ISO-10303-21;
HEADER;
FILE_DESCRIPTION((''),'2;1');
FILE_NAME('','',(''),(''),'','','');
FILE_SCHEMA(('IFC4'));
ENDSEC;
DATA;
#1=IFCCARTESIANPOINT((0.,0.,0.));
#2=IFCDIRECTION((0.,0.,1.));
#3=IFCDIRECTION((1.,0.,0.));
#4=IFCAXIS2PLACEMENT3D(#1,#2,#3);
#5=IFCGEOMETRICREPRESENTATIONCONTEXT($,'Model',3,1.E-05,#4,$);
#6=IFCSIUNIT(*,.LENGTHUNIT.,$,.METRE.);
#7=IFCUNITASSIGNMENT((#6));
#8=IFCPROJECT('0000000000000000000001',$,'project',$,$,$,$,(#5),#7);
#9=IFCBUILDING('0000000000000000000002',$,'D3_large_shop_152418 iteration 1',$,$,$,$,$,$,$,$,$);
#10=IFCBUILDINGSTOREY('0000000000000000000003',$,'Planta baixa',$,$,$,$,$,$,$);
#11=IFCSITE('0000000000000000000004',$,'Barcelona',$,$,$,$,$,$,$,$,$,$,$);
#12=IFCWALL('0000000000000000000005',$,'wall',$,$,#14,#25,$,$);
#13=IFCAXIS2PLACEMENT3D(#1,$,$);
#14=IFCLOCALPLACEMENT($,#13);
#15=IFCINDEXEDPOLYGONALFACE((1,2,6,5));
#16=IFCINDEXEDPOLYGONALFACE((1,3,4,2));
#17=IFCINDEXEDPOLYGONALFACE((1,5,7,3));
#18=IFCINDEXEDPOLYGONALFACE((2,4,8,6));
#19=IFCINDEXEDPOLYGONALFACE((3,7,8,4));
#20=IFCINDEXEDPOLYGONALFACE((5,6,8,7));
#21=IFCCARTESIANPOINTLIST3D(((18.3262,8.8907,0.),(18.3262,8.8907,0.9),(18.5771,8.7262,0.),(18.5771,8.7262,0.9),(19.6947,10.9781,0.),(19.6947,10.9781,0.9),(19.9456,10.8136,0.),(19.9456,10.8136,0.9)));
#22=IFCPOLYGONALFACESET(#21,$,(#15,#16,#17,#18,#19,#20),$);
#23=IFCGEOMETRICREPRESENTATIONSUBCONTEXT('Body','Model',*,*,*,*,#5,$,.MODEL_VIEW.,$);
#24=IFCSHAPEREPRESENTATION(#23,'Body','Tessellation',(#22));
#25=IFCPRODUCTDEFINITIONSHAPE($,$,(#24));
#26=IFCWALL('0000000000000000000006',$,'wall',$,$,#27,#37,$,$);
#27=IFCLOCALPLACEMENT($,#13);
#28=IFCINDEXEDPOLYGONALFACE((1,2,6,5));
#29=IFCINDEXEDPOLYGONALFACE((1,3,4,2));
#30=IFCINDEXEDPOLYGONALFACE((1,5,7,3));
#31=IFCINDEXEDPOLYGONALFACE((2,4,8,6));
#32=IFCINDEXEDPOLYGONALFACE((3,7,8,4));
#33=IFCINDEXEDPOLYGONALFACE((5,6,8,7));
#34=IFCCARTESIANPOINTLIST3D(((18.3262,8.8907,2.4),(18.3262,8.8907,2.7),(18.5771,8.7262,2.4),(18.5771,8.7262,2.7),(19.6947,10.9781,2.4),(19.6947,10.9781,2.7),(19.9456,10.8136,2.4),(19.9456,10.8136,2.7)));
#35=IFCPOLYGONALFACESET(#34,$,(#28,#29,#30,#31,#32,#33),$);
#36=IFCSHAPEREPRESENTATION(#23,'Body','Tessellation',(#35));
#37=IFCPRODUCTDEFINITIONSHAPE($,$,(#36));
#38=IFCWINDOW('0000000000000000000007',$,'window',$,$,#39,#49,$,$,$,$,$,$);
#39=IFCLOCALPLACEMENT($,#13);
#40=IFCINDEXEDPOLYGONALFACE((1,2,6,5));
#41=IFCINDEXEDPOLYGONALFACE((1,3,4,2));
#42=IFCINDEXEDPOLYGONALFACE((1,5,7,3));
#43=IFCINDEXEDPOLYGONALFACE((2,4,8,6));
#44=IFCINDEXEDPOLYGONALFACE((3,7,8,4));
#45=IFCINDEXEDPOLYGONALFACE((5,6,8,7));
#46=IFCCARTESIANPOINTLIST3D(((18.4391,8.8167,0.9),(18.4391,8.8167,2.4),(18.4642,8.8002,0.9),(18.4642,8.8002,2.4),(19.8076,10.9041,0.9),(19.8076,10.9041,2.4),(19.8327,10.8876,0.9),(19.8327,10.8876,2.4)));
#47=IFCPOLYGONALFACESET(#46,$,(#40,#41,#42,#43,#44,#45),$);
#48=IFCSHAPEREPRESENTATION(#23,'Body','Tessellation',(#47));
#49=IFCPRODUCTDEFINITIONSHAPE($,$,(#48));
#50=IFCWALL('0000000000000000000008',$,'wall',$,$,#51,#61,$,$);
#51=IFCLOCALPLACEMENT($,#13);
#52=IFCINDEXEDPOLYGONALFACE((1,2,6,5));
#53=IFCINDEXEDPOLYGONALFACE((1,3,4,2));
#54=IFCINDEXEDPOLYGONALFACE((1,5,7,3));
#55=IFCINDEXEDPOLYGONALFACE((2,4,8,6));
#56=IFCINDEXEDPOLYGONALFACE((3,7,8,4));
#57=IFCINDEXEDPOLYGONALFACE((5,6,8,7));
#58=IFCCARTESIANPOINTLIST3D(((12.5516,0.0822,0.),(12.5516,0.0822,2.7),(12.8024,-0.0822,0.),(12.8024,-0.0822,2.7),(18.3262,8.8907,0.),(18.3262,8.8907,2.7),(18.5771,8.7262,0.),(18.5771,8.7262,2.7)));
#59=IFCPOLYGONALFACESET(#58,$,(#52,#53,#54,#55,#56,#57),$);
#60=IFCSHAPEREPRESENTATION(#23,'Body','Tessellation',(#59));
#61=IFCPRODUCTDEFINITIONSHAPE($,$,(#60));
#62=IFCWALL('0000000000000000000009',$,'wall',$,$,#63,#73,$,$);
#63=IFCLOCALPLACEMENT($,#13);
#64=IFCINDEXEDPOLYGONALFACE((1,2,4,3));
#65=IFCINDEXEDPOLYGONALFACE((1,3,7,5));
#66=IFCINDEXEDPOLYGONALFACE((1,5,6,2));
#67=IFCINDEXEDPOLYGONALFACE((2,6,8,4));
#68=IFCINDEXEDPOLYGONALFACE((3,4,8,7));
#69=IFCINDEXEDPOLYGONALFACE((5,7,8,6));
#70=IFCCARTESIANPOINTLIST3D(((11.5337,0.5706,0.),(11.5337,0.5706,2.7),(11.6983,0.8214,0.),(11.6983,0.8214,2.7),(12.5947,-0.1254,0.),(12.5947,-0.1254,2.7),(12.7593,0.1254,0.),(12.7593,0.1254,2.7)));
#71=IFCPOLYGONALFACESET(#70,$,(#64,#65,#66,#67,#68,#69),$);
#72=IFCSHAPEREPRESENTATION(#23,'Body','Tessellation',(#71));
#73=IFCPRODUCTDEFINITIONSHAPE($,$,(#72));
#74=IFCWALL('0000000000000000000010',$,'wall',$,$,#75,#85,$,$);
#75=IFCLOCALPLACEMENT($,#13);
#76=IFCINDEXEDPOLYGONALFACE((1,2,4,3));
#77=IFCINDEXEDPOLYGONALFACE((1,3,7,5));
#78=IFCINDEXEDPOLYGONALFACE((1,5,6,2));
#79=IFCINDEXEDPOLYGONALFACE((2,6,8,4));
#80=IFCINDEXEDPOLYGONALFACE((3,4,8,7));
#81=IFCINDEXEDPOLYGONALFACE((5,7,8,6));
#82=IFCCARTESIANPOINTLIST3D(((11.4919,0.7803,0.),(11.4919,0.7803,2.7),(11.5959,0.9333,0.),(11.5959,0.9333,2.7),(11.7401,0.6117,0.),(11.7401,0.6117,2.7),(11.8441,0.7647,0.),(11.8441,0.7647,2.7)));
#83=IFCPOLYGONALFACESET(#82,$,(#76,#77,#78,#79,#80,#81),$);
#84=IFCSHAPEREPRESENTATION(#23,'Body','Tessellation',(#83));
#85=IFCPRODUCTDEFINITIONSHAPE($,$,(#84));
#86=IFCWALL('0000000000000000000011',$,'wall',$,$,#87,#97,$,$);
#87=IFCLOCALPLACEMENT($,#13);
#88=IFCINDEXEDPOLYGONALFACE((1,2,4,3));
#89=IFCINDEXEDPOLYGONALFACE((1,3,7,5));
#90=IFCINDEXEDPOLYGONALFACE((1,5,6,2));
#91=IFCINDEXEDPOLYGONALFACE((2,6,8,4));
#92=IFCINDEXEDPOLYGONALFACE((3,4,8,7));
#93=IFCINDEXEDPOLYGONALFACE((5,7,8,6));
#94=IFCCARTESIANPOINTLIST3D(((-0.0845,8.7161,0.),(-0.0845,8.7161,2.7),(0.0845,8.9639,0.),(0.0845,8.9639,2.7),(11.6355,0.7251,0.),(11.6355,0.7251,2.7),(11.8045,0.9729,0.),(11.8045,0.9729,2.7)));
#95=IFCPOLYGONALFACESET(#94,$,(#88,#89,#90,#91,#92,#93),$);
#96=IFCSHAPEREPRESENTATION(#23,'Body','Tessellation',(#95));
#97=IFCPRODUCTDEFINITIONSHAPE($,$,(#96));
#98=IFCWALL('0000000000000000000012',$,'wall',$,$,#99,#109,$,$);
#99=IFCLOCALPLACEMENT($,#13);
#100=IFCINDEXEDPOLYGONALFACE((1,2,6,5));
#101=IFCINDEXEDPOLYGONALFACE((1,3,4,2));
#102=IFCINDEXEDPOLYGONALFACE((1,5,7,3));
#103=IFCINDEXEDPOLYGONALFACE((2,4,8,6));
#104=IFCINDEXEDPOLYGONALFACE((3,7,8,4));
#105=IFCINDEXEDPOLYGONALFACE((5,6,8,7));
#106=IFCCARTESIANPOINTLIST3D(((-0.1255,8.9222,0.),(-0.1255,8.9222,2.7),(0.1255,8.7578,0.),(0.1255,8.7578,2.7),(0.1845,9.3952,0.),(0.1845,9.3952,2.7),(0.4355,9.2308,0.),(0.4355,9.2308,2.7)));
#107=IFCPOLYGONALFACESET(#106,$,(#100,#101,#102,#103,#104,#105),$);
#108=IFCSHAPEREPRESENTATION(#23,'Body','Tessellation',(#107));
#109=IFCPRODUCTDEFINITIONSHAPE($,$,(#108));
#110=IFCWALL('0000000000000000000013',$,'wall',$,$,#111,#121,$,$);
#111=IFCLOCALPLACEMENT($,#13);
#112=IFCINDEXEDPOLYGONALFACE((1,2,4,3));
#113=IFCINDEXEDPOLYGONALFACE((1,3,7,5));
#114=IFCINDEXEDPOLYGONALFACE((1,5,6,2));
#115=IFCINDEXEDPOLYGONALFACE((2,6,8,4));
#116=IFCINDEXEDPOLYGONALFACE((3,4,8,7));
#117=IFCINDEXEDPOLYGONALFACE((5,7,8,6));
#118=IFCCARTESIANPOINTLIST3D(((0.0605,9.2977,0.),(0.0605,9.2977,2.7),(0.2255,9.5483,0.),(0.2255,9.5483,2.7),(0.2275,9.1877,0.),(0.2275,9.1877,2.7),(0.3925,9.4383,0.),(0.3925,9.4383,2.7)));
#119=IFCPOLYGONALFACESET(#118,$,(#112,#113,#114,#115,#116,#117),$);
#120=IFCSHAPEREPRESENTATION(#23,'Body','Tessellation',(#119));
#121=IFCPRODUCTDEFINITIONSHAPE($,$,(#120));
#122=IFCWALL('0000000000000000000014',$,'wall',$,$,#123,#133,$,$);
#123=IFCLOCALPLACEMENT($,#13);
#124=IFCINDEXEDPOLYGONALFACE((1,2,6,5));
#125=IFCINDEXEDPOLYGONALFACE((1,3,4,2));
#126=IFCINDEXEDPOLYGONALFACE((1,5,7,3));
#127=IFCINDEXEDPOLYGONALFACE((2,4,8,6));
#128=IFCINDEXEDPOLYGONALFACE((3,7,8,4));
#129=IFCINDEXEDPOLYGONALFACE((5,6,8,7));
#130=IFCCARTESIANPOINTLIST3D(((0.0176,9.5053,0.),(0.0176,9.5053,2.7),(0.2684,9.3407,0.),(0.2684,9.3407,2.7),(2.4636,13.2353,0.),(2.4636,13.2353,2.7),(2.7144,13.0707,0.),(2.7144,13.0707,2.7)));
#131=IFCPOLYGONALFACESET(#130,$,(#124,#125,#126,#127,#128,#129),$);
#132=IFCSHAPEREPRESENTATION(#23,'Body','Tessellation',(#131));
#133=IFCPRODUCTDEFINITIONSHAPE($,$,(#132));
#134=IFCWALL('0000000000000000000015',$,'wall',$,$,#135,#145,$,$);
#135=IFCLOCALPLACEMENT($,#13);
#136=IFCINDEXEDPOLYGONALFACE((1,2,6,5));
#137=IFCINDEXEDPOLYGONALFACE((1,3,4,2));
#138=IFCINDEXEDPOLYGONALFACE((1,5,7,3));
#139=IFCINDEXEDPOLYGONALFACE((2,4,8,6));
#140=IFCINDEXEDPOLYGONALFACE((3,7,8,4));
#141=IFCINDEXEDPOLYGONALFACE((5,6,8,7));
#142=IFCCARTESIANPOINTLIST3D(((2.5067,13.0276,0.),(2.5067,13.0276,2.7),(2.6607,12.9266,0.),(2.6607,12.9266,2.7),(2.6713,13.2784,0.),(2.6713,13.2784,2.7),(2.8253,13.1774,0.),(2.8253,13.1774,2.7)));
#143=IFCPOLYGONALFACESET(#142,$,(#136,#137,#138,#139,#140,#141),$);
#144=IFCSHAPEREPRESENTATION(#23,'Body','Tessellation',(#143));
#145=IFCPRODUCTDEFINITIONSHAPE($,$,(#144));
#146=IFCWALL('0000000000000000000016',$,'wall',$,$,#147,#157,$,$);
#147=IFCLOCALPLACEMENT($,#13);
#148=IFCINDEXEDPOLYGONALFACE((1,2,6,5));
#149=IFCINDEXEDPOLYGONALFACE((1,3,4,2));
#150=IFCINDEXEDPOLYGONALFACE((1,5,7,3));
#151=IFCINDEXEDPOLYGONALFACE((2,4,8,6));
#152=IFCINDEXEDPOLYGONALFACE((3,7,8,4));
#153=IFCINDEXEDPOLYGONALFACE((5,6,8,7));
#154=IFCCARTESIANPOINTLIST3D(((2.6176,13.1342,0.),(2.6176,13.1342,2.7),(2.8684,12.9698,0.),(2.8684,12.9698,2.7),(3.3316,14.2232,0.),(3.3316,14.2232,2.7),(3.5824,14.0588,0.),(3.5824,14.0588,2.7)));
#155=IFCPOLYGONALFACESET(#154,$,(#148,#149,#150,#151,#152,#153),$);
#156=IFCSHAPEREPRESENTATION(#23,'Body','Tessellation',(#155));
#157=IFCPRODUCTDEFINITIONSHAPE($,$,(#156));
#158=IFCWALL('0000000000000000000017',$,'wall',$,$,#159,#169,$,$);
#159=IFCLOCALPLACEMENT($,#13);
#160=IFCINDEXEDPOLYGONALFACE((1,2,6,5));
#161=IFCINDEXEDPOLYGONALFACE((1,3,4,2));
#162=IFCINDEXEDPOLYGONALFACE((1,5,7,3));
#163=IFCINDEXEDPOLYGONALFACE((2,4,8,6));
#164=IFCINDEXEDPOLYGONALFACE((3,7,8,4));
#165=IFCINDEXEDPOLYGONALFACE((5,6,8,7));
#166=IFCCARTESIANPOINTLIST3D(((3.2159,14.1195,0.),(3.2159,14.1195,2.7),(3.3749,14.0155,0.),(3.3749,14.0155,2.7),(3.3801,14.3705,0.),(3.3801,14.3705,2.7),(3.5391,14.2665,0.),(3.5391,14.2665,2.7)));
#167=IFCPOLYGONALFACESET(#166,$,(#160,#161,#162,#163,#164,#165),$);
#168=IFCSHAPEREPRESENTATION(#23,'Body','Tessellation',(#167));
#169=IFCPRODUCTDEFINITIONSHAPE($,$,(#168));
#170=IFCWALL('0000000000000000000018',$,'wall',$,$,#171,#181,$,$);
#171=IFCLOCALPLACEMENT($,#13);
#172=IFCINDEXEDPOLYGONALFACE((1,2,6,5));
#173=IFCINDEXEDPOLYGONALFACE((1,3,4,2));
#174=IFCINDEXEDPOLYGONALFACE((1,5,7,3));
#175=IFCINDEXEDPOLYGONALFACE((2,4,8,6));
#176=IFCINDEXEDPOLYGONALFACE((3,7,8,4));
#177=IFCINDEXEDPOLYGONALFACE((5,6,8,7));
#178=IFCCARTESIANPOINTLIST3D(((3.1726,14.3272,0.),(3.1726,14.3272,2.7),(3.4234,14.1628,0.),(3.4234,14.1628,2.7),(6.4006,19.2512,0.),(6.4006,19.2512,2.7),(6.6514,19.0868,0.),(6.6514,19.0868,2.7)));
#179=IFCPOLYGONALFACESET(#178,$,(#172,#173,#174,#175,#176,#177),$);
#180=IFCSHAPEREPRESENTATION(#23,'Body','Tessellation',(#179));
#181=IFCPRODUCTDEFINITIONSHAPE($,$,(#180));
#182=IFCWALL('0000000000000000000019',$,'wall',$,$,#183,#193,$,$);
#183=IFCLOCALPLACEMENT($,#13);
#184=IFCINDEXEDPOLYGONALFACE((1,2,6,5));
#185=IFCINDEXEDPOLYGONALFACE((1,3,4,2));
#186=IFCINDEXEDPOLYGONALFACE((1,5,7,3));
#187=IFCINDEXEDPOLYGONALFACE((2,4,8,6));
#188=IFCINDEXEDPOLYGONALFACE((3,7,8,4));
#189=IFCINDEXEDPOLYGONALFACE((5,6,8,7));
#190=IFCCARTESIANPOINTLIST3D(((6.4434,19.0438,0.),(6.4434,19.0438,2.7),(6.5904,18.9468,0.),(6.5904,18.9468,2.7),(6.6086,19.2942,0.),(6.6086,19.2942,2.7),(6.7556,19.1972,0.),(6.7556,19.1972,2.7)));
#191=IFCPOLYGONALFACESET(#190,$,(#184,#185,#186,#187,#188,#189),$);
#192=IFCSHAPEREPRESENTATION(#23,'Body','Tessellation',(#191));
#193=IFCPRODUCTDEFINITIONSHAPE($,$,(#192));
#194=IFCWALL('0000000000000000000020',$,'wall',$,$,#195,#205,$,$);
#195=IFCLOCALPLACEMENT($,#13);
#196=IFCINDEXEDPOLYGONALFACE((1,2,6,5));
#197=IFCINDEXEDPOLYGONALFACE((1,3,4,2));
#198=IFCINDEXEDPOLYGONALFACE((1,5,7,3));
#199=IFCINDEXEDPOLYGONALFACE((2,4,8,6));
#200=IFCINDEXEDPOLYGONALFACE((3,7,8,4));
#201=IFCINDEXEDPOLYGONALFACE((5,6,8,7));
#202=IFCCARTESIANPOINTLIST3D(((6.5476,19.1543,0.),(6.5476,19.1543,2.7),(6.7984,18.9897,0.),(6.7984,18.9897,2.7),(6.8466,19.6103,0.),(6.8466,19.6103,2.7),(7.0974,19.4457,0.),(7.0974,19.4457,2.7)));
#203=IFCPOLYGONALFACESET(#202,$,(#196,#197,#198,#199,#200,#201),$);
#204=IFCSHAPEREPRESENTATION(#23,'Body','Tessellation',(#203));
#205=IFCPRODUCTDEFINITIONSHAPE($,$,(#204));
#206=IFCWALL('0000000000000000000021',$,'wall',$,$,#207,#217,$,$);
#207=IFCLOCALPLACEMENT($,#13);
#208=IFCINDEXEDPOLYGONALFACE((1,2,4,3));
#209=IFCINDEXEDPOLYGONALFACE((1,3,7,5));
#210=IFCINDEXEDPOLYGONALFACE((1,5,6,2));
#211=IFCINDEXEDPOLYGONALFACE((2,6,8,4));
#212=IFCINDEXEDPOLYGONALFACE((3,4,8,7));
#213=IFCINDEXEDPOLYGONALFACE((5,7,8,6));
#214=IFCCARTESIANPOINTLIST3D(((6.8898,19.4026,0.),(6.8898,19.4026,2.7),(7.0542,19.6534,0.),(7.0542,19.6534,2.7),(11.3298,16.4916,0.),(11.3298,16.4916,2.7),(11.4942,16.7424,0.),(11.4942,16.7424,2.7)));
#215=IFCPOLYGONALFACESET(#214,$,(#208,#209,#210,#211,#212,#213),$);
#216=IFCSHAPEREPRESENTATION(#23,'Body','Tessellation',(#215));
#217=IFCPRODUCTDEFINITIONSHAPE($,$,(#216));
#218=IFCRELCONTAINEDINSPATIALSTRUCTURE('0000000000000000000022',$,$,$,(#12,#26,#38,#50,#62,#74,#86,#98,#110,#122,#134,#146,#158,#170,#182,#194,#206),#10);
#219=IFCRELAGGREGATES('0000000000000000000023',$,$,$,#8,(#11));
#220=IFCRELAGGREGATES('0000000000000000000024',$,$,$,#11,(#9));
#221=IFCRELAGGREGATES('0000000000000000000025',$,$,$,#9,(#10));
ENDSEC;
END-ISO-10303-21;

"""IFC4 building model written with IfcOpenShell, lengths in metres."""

from ifc_helpers import new_model, si_unit, frame, origin, origin_with_axes, place, context, subcontext, project, spatial, polyline, outline, extrude, element, save


model = new_model("IFC4")

# Units and contexts
model_context = context("Model", 3, precision=1e-05, world=origin_with_axes())
body_context = subcontext(model_context, "Body", "Model", "MODEL_VIEW")
ifc_project = project(units=[si_unit("LENGTHUNIT", "METRE")], contexts=[model_context])

# Site, building, storey
site = spatial("IfcSite", under=ifc_project, Name="Barcelona")
building = spatial("IfcBuilding", under=site, Name="D3_large_shop_152418 iteration 1")
storey = spatial("IfcBuildingStorey", under=building, Name="Planta baixa")

# Walls
wall_1_placement = place(None, origin_with_axes())
element("IfcWall", 1, at=wall_1_placement, inside=storey, Name="wall", context=body_context, shape_type="SweptSolid", body=[
    extrude(outline(polyline([(19.9456, 10.8136), (18.5771, 8.7262), (18.3262, 8.8907), (19.6947, 10.9781), (19.9456, 10.8136)])), origin(), (0.0, 0.0, 1.0), 0.9),
])
wall_2_placement = place(None, origin_with_axes())
element("IfcWall", 2, at=wall_2_placement, inside=storey, Name="wall", context=body_context, shape_type="SweptSolid", body=[
    extrude(outline(polyline([(19.9456, 10.8136), (18.5771, 8.7262), (18.3262, 8.8907), (19.6947, 10.9781), (19.9456, 10.8136)])), frame((0.0, 0.0, 2.4)), (0.0, 0.0, 1.0), 0.3),
])

# Window
window_placement = place(None, origin_with_axes())
element("IfcWindow", 3, at=window_placement, inside=storey, Name="window", context=body_context, shape_type="SweptSolid", body=[
    extrude(outline(polyline([(19.8327, 10.8876), (18.4642, 8.8002), (18.4391, 8.8167), (19.8076, 10.9041), (19.8327, 10.8876)])), frame((0.0, 0.0, 0.9)), (0.0, 0.0, 1.0), 1.5),
])

# Walls
wall_3_placement = place(None, origin_with_axes())
element("IfcWall", 4, at=wall_3_placement, inside=storey, Name="wall", context=body_context, shape_type="SweptSolid", body=[
    extrude(outline(polyline([(18.5771, 8.7262), (12.8024, -0.0822), (12.5516, 0.0822), (18.3262, 8.8907), (18.5771, 8.7262)])), origin(), (0.0, 0.0, 1.0), 2.7),
])
wall_4_placement = place(None, origin_with_axes())
element("IfcWall", 5, at=wall_4_placement, inside=storey, Name="wall", context=body_context, shape_type="SweptSolid", body=[
    extrude(outline(polyline([(12.5947, -0.1254), (11.5337, 0.5706), (11.6983, 0.8214), (12.7593, 0.1254), (12.5947, -0.1254)])), origin(), (0.0, 0.0, 1.0), 2.7),
])
wall_5_placement = place(None, origin_with_axes())
element("IfcWall", 6, at=wall_5_placement, inside=storey, Name="wall", context=body_context, shape_type="SweptSolid", body=[
    extrude(outline(polyline([(11.4919, 0.7803), (11.5959, 0.9333), (11.8441, 0.7647), (11.7401, 0.6117), (11.4919, 0.7803)])), origin(), (0.0, 0.0, 1.0), 2.7),
])
wall_6_placement = place(None, origin_with_axes())
element("IfcWall", 7, at=wall_6_placement, inside=storey, Name="wall", context=body_context, shape_type="SweptSolid", body=[
    extrude(outline(polyline([(11.6355, 0.7251), (-0.0845, 8.7161), (0.0845, 8.9639), (11.8045, 0.9729), (11.6355, 0.7251)])), origin(), (0.0, 0.0, 1.0), 2.7),
])
wall_7_placement = place(None, origin_with_axes())
element("IfcWall", 8, at=wall_7_placement, inside=storey, Name="wall", context=body_context, shape_type="SweptSolid", body=[
    extrude(outline(polyline([(-0.1255, 8.9222), (0.1845, 9.3952), (0.4355, 9.2308), (0.1255, 8.7578), (-0.1255, 8.9222)])), origin(), (0.0, 0.0, 1.0), 2.7),
])
wall_8_placement = place(None, origin_with_axes())
element("IfcWall", 9, at=wall_8_placement, inside=storey, Name="wall", context=body_context, shape_type="SweptSolid", body=[
    extrude(outline(polyline([(0.2275, 9.1877), (0.0605, 9.2977), (0.2255, 9.5483), (0.3925, 9.4383), (0.2275, 9.1877)])), origin(), (0.0, 0.0, 1.0), 2.7),
])
wall_9_placement = place(None, origin_with_axes())
element("IfcWall", 10, at=wall_9_placement, inside=storey, Name="wall", context=body_context, shape_type="SweptSolid", body=[
    extrude(outline(polyline([(0.0176, 9.5053), (2.4636, 13.2353), (2.7144, 13.0707), (0.2684, 9.3407), (0.0176, 9.5053)])), origin(), (0.0, 0.0, 1.0), 2.7),
])
wall_10_placement = place(None, origin_with_axes())
element("IfcWall", 11, at=wall_10_placement, inside=storey, Name="wall", context=body_context, shape_type="SweptSolid", body=[
    extrude(outline(polyline([(2.6713, 13.2784), (2.8253, 13.1774), (2.6607, 12.9266), (2.5067, 13.0276), (2.6713, 13.2784)])), origin(), (0.0, 0.0, 1.0), 2.7),
])
wall_11_placement = place(None, origin_with_axes())
element("IfcWall", 12, at=wall_11_placement, inside=storey, Name="wall", context=body_context, shape_type="SweptSolid", body=[
    extrude(outline(polyline([(2.6176, 13.1342), (3.3316, 14.2232), (3.5824, 14.0588), (2.8684, 12.9698), (2.6176, 13.1342)])), origin(), (0.0, 0.0, 1.0), 2.7),
])
wall_12_placement = place(None, origin_with_axes())
element("IfcWall", 13, at=wall_12_placement, inside=storey, Name="wall", context=body_context, shape_type="SweptSolid", body=[
    extrude(outline(polyline([(3.3749, 14.0155), (3.2159, 14.1195), (3.3801, 14.3705), (3.5391, 14.2665), (3.3749, 14.0155)])), origin(), (0.0, 0.0, 1.0), 2.7),
])
wall_13_placement = place(None, origin_with_axes())
element("IfcWall", 14, at=wall_13_placement, inside=storey, Name="wall", context=body_context, shape_type="SweptSolid", body=[
    extrude(outline(polyline([(3.1726, 14.3272), (6.4006, 19.2512), (6.6514, 19.0868), (3.4234, 14.1628), (3.1726, 14.3272)])), origin(), (0.0, 0.0, 1.0), 2.7),
])
wall_14_placement = place(None, origin_with_axes())
element("IfcWall", 15, at=wall_14_placement, inside=storey, Name="wall", context=body_context, shape_type="SweptSolid", body=[
    extrude(outline(polyline([(6.6086, 19.2942), (6.7556, 19.1972), (6.5904, 18.9468), (6.4434, 19.0438), (6.6086, 19.2942)])), origin(), (0.0, 0.0, 1.0), 2.7),
])
wall_15_placement = place(None, origin_with_axes())
element("IfcWall", 16, at=wall_15_placement, inside=storey, Name="wall", context=body_context, shape_type="SweptSolid", body=[
    extrude(outline(polyline([(6.5476, 19.1543), (6.8466, 19.6103), (7.0974, 19.4457), (6.7984, 18.9897), (6.5476, 19.1543)])), origin(), (0.0, 0.0, 1.0), 2.7),
])
wall_16_placement = place(None, origin_with_axes())
element("IfcWall", 17, at=wall_16_placement, inside=storey, Name="wall", context=body_context, shape_type="SweptSolid", body=[
    extrude(outline(polyline([(7.0542, 19.6534), (11.4942, 16.7424), (11.3298, 16.4916), (6.8898, 19.4026), (7.0542, 19.6534)])), origin(), (0.0, 0.0, 1.0), 2.7),
])

save(model, "model.ifc")
